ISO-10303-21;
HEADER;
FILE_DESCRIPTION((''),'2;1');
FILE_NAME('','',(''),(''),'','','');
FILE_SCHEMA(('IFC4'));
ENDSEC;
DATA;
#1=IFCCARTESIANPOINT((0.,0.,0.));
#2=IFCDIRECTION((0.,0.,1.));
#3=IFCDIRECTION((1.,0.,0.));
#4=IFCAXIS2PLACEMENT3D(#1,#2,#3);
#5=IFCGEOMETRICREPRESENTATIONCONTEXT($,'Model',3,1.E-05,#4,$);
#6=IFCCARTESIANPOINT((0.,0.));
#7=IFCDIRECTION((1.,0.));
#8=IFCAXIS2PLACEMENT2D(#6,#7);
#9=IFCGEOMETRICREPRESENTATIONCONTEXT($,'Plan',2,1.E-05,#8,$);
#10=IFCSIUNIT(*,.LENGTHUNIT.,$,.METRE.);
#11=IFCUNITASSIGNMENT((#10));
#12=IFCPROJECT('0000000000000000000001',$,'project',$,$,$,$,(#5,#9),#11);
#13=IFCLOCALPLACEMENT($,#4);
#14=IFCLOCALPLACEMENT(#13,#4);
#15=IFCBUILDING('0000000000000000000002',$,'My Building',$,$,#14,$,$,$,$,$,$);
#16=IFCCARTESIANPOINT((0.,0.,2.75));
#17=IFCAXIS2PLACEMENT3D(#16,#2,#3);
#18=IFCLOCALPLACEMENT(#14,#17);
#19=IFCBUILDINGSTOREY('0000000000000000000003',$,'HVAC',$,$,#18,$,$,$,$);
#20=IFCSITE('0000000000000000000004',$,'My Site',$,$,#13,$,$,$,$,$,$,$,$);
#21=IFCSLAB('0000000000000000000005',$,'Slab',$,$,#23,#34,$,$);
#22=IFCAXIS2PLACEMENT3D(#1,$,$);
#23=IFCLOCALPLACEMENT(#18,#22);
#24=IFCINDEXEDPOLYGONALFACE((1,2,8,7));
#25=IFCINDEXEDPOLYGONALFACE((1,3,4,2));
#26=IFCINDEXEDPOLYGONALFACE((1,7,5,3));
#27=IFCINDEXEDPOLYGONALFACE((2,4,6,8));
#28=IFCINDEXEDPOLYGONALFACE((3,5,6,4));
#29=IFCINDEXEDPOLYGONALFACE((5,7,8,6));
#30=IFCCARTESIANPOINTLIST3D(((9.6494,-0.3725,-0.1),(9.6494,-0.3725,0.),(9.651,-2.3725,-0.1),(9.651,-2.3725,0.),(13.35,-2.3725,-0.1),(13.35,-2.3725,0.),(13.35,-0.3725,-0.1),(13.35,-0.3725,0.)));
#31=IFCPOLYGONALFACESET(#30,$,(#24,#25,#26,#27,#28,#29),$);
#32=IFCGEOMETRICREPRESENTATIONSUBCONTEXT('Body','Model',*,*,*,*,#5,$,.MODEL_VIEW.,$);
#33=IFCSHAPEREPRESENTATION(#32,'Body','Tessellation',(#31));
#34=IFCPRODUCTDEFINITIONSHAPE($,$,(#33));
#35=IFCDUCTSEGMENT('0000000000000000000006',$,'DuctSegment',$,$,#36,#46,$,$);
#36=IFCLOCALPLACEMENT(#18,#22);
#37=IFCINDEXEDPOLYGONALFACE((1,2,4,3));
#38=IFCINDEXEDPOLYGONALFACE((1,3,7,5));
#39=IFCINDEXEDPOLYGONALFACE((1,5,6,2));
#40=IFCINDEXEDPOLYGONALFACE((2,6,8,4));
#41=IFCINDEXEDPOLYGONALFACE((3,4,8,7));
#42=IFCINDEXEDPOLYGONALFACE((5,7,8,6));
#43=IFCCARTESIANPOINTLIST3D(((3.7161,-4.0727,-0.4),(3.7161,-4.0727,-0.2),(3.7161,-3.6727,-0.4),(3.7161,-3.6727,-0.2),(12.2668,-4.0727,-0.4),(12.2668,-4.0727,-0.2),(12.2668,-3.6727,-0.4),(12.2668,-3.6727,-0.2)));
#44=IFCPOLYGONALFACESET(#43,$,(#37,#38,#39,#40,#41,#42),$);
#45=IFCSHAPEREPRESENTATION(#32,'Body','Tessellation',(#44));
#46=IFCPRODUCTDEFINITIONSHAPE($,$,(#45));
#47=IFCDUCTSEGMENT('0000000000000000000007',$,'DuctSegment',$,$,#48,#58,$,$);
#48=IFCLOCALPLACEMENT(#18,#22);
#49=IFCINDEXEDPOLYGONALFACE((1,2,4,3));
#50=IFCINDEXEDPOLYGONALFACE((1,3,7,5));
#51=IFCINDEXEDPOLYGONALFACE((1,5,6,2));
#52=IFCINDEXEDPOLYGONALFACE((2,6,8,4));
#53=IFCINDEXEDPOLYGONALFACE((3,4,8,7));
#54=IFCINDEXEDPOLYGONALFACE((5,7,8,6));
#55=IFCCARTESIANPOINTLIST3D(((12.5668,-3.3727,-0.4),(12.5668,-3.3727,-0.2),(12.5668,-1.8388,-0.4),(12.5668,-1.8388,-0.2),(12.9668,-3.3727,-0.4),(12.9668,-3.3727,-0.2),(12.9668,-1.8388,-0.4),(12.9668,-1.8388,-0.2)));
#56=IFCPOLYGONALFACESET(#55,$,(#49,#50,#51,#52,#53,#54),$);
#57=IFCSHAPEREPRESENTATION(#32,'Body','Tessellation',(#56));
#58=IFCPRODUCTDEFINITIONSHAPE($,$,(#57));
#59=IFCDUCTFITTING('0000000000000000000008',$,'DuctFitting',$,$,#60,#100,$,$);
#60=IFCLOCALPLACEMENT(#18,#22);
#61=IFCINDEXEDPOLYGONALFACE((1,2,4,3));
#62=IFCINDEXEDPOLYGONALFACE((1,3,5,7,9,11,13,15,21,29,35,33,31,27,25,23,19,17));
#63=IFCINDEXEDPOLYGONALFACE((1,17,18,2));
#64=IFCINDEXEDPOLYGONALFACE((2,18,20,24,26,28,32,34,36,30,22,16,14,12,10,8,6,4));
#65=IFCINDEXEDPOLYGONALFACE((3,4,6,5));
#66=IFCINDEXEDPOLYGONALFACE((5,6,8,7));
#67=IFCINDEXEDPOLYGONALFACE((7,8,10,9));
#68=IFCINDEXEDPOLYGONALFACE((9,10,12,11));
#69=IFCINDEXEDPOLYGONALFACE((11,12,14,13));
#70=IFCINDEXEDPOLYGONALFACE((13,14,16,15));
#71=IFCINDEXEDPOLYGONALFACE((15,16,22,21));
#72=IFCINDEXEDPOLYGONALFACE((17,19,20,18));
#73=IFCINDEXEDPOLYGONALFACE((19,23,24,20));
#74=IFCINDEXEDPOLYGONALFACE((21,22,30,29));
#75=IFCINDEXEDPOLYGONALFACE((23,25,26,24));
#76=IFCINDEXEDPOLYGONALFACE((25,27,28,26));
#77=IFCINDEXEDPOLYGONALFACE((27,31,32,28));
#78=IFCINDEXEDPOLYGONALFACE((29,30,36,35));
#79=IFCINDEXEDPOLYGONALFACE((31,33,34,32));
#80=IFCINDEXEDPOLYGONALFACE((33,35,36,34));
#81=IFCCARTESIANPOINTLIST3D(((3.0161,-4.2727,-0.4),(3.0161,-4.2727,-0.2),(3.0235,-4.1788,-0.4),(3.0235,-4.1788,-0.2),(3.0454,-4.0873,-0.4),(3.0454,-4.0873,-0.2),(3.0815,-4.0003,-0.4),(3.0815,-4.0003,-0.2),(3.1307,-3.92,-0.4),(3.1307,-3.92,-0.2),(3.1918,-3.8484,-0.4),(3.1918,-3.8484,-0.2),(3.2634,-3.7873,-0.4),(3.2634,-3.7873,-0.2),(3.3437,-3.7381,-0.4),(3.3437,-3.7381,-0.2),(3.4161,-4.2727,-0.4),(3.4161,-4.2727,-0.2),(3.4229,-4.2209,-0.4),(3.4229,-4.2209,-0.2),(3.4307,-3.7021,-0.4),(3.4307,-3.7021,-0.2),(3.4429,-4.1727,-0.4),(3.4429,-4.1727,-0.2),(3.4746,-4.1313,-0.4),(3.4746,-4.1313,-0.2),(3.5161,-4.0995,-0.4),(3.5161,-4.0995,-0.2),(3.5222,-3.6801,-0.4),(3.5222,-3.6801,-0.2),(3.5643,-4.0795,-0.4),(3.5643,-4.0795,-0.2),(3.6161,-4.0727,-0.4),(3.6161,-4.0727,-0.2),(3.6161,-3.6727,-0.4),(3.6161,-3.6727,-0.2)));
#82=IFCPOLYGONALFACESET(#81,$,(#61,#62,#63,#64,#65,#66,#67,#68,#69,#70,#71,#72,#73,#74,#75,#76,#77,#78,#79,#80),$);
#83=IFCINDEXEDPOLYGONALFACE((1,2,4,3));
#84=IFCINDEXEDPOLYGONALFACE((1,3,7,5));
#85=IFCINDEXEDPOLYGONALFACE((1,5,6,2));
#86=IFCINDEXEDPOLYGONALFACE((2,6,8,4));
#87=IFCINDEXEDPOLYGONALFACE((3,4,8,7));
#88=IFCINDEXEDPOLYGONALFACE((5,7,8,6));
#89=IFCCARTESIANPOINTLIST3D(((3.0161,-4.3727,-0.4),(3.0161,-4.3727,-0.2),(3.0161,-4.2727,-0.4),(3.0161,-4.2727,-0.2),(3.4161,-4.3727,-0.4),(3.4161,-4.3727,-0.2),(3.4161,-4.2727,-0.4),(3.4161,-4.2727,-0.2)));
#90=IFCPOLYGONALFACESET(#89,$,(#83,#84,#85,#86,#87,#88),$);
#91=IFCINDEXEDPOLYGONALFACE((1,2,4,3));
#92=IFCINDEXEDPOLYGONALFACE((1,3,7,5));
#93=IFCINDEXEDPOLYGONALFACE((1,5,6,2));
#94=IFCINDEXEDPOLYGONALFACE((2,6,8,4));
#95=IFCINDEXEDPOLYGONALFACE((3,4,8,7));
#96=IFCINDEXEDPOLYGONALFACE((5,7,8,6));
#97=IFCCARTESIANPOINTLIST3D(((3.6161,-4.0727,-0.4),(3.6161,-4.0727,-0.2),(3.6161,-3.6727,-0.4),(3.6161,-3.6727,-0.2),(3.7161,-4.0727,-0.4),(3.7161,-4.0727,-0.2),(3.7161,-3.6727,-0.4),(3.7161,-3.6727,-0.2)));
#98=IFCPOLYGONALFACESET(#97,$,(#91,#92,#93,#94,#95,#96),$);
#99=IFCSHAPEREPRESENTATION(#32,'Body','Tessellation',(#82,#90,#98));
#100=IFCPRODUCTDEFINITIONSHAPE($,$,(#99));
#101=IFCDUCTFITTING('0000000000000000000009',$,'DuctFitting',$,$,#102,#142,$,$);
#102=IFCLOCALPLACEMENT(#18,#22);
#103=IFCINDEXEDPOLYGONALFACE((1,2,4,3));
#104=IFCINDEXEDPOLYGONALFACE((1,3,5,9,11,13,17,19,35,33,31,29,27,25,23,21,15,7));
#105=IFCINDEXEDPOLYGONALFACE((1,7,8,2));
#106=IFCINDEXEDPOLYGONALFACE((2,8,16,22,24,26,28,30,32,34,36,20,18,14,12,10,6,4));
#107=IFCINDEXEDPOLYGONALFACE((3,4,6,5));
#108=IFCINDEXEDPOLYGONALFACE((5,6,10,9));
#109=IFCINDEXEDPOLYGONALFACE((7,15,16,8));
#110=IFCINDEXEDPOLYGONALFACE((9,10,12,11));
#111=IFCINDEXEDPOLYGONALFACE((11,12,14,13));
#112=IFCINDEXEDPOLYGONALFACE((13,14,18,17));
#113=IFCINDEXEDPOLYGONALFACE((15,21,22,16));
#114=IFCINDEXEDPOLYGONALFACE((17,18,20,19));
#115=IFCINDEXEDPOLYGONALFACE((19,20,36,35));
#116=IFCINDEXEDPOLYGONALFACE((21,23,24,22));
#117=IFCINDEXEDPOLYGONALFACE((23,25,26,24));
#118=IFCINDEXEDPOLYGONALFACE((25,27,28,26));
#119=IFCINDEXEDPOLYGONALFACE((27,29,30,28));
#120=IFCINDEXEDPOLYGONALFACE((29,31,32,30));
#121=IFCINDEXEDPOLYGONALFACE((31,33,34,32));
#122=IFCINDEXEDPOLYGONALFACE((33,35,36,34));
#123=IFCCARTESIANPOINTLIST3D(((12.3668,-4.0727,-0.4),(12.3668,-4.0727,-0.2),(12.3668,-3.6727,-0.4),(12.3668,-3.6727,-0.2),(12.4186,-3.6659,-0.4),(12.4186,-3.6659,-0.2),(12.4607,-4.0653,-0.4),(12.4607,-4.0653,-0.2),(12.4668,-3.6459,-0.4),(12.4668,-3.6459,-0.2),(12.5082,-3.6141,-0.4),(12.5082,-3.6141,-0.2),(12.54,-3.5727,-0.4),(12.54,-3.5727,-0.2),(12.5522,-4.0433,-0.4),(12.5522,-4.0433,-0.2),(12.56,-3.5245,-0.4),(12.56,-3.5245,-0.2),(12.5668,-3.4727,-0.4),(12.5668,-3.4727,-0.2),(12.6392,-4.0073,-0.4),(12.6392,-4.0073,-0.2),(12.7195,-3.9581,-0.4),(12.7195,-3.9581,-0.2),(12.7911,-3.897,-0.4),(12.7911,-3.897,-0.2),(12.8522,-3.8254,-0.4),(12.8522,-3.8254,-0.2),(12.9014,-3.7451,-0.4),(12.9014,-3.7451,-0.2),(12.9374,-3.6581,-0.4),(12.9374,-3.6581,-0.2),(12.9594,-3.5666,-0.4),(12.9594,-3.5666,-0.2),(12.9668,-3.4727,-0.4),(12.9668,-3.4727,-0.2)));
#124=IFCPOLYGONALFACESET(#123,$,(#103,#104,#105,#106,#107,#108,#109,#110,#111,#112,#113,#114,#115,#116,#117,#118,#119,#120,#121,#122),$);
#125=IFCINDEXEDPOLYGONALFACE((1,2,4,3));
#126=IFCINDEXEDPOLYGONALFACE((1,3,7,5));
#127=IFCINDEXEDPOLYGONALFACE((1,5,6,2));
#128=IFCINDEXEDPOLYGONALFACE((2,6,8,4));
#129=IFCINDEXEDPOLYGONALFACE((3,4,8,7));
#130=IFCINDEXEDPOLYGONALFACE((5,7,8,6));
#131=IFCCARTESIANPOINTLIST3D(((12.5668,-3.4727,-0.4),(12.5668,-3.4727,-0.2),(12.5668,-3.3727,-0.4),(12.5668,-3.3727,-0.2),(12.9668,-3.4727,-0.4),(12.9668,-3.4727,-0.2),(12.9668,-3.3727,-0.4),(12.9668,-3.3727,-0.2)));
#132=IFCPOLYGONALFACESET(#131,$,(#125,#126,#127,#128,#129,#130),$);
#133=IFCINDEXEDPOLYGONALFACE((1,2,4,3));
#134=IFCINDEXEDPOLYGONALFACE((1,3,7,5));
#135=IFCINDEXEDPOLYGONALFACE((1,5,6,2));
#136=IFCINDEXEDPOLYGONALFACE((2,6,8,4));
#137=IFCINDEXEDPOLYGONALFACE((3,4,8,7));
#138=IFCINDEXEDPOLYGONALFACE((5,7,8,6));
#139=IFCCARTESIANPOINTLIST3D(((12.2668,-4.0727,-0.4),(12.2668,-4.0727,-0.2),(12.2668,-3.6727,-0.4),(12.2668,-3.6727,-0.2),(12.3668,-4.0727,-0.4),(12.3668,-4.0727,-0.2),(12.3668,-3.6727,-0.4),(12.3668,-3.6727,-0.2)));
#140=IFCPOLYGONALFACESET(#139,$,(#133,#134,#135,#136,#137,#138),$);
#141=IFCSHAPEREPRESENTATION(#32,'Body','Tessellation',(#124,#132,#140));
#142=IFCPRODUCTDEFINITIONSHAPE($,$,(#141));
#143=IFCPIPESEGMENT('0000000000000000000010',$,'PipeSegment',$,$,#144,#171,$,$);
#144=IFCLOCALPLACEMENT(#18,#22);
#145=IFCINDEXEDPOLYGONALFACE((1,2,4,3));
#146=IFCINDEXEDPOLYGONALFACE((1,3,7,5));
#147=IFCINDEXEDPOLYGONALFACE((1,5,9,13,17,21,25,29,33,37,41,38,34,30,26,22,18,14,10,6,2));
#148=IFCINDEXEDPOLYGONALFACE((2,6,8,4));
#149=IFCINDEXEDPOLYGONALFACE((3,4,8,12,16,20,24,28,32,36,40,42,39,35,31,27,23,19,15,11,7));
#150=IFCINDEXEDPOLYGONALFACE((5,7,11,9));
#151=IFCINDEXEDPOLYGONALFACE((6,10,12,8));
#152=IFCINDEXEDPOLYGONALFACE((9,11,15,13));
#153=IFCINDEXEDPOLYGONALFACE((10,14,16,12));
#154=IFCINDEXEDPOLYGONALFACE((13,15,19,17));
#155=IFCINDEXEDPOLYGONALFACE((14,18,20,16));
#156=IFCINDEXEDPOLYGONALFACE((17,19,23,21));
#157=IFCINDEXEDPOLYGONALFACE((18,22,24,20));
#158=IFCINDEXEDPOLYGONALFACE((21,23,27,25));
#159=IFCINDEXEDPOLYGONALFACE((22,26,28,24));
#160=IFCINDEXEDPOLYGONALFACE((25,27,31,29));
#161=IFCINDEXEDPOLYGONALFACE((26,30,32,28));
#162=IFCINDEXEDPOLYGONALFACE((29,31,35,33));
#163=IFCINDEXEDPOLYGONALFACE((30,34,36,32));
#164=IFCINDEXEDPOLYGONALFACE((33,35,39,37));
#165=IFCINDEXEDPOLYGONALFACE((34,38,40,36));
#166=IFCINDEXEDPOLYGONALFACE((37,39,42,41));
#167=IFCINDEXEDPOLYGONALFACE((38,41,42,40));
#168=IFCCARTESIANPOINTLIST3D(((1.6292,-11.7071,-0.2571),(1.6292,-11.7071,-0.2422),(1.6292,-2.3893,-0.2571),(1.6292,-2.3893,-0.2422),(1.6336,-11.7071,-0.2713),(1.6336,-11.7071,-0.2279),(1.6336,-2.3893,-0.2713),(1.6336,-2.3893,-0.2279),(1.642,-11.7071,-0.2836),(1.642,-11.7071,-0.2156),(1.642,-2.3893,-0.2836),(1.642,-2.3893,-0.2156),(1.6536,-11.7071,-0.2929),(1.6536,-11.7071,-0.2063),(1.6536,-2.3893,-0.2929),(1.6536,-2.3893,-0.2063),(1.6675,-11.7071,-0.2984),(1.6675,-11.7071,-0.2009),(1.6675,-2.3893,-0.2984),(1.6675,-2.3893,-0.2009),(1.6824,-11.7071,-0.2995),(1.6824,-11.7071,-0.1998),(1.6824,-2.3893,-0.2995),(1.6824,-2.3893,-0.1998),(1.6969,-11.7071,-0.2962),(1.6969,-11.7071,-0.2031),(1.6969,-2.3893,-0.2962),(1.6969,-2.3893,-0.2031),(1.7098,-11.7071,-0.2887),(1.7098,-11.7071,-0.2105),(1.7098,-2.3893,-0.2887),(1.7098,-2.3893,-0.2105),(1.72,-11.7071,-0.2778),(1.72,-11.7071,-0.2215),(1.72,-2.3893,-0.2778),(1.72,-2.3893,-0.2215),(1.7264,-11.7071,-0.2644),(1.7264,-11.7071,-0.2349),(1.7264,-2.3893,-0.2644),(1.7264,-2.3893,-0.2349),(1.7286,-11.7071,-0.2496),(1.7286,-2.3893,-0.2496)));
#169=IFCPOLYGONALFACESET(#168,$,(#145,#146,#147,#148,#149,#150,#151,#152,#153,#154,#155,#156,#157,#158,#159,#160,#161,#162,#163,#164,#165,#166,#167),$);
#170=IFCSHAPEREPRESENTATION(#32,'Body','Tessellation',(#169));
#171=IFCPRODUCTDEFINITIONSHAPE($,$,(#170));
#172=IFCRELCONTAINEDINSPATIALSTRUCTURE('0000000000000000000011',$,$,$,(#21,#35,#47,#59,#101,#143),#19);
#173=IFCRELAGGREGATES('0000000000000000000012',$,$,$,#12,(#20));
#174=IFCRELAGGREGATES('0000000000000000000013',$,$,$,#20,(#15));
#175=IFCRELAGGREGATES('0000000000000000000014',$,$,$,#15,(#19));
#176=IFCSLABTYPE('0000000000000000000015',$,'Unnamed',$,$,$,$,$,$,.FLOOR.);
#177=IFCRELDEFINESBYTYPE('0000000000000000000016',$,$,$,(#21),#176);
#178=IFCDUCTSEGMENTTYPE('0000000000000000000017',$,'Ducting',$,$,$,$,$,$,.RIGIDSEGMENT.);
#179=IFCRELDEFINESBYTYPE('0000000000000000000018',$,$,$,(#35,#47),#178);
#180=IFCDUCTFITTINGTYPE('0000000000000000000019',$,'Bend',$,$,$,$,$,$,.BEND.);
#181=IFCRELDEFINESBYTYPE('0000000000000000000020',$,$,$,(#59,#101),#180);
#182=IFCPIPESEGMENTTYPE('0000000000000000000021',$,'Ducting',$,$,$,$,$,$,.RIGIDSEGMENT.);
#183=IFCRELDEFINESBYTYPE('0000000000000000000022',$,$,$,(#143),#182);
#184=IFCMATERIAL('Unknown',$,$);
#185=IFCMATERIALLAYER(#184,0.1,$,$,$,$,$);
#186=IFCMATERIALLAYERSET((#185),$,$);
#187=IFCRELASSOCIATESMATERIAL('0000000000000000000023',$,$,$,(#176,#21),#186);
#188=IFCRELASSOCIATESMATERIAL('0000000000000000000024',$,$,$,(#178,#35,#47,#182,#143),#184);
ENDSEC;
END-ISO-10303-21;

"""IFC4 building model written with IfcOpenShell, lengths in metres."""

from ifc_helpers import new_model, si_unit, frame, origin_with_axes, origin_2d_with_axis, place, context, subcontext, project, spatial, line, arc, indexed_curve, rectangle, circle, outline, extrude, source, transform, mapped, material, layer, layer_set, layer_usage, material_profile, profile_set, profile_usage, type_object, type_shapes, element, save


model = new_model("IFC4")

# Units and contexts
model_context = context("Model", 3, precision=1e-05, world=origin_with_axes())
plan_context = context("Plan", 2, precision=1e-05, world=origin_2d_with_axis())
body_context = subcontext(model_context, "Body", "Model", "MODEL_VIEW")
ifc_project = project(units=[si_unit("LENGTHUNIT", "METRE")], contexts=[model_context, plan_context])

# Site, building, storey
site_placement = place(None, origin_with_axes())
site = spatial("IfcSite", under=ifc_project, at=site_placement, Name="My Site")
building_placement = place(site_placement, origin_with_axes())
building = spatial("IfcBuilding", under=site, at=building_placement, Name="My Building")
storey_placement = place(building_placement, frame((0.0, 0.0, 2.75), z_axis=(0.0, 0.0, 1.0), x_axis=(1.0, 0.0, 0.0)))
storey = spatial("IfcBuildingStorey", under=building, at=storey_placement, Name="HVAC")

# Slab
ifc_material = material(Name="Unknown")
ifc_layer = layer(ifc_material, 0.1)
ifc_layer_set = layer_set([ifc_layer])
ifc_layer_usage = layer_usage(ifc_layer_set, "AXIS3", "POSITIVE", -0.1)
slab_type = type_object("IfcSlabType", Name="Unnamed", PredefinedType="FLOOR", material=ifc_layer_set)
slab_placement = place(storey_placement, frame((9.651, -2.3725, 0.0), z_axis=(0.0, 0.0, 1.0), x_axis=(1.0, 0.0, 0.0)))
element("IfcSlab", 1, at=slab_placement, inside=storey, type_object=slab_type, material=ifc_layer_usage, Name="Slab", context=body_context, shape_type="SweptSolid", body=[
    extrude(outline(indexed_curve([(0.0, 0.0), (3.699, 0.0), (3.699, 2.0), (-0.0016, 2.0), (0.0, 0.0)])), frame((0.0, 0.0, -0.1), z_axis=(0.0, 0.0, 1.0), x_axis=(1.0, 0.0, 0.0)), (0.0, 0.0, 1.0), 0.1),
])

# Duct segments
ifc_material_profile_1 = material_profile(ifc_material, rectangle(XDim=0.4, YDim=0.2))
ifc_profile_set_1 = profile_set([ifc_material_profile_1])
ifc_profile_usage_1 = profile_usage(ifc_profile_set_1, cardinal=4)
duct_segment_type = type_object("IfcDuctSegmentType", Name="Ducting", PredefinedType="RIGIDSEGMENT", material=ifc_profile_set_1)
duct_segment_1_placement = place(storey_placement, frame((3.7161, -3.6727, -0.3), z_axis=(1.0, 0.0, 0.0), x_axis=(0.0, 1.0, 0.0)))
element("IfcDuctSegment", 2, at=duct_segment_1_placement, inside=storey, type_object=duct_segment_type, material=ifc_profile_usage_1, Name="DuctSegment", context=body_context, shape_type="SweptSolid", body=[
    extrude(rectangle(XDim=0.4, YDim=0.2), frame((-0.2, 0.0, 0.0), z_axis=(0.0, 0.0, 1.0), x_axis=(1.0, 0.0, 0.0)), (0.0, 0.0, 1.0), 8.5507),
])
ifc_profile_usage_2 = profile_usage(ifc_profile_set_1, cardinal=4)
duct_segment_2_placement = place(storey_placement, frame((12.5668, -3.3727, -0.3), z_axis=(0.0, 1.0, -0.000002), x_axis=(-1.0, 0.0, 0.0)))
element("IfcDuctSegment", 3, at=duct_segment_2_placement, inside=storey, type_object=duct_segment_type, material=ifc_profile_usage_2, Name="DuctSegment", context=body_context, shape_type="SweptSolid", body=[
    extrude(rectangle(XDim=0.4, YDim=0.2), frame((-0.2, 0.0, 0.0), z_axis=(0.0, 0.0, 1.0), x_axis=(1.0, 0.0, 0.0)), (0.0, 0.0, 1.0), 1.5339),
])

# Duct fittings
duct_fitting_type = type_object("IfcDuctFittingType", Name="Bend", PredefinedType="BEND")
shared_shape = source(origin_with_axes(), body_context, "Body", "SweptSolid", [
    extrude(outline(indexed_curve([(-0.2, 0.0), (-0.2586, -0.1414), (-0.4, -0.2), (-0.4, -0.6), (0.0243, -0.4243), (0.2, 0.0)], segments=[arc(1, 2, 3), line(3, 4), arc(4, 5, 6), line(6, 1)])), frame((0.0, -0.1, -0.1), z_axis=(0.0, -1.0, 0.0), x_axis=(1.0, 0.0, 0.0)), (0.0, 0.0, -1.0), 0.2),
    extrude(rectangle(XDim=0.4, YDim=0.2), origin_with_axes(), (0.0, 0.0, -1.0), 0.1),
    extrude(rectangle(XDim=0.4, YDim=0.2), frame((-0.4, 0.0, -0.5), z_axis=(-1.0, 0.0, 0.0), x_axis=(0.0, 0.0, -1.0)), (0.0, 0.0, 1.0), 0.1),
])
type_shapes(duct_fitting_type, [shared_shape])
for number, where, z_axis, x_axis, name in (
    (4, (3.2161, -4.3727, -0.3), (0.0, -1.0, 0.0), (-1.0, 0.0, 0.0), "DuctFitting"),
    (5, (12.7668, -3.3727, -0.3), (0.0, 1.0, 0.0), (1.0, 0.0, 0.0), "DuctFitting"),
):
    element("IfcDuctFitting", number, at=place(storey_placement, frame(where, z_axis=z_axis, x_axis=x_axis)), inside=storey, type_object=duct_fitting_type, Name=name, context=body_context, shape_type="MappedRepresentation", body=[
        mapped(shared_shape, transform((0.0, 0.0, 0.0), x_axis=(1.0, 0.0, 0.0), y_axis=(0.0, 1.0, 0.0), z_axis=(0.0, 0.0, 1.0), scale=1.0)),
    ])

# Pipe segment
ifc_material_profile_2 = material_profile(ifc_material, circle(Radius=0.05))
ifc_profile_set_2 = profile_set([ifc_material_profile_2])
ifc_profile_usage_3 = profile_usage(ifc_profile_set_2, cardinal=4)
pipe_segment_type = type_object("IfcPipeSegmentType", Name="Ducting", PredefinedType="RIGIDSEGMENT", material=ifc_profile_set_2)
pipe_segment_placement = place(storey_placement, frame((1.7286, -2.3893, -0.2496), z_axis=(0.0, -1.0, 0.0), x_axis=(1.0, 0.0, 0.0)))
element("IfcPipeSegment", 6, at=pipe_segment_placement, inside=storey, type_object=pipe_segment_type, material=ifc_profile_usage_3, Name="PipeSegment", context=body_context, shape_type="SweptSolid", body=[
    extrude(circle(Radius=0.05), frame((-0.05, 0.0, 0.0), z_axis=(0.0, 0.0, 1.0), x_axis=(1.0, 0.0, 0.0)), (0.0, 0.0, 1.0), 9.3178),
])

save(model, "model.ifc")
